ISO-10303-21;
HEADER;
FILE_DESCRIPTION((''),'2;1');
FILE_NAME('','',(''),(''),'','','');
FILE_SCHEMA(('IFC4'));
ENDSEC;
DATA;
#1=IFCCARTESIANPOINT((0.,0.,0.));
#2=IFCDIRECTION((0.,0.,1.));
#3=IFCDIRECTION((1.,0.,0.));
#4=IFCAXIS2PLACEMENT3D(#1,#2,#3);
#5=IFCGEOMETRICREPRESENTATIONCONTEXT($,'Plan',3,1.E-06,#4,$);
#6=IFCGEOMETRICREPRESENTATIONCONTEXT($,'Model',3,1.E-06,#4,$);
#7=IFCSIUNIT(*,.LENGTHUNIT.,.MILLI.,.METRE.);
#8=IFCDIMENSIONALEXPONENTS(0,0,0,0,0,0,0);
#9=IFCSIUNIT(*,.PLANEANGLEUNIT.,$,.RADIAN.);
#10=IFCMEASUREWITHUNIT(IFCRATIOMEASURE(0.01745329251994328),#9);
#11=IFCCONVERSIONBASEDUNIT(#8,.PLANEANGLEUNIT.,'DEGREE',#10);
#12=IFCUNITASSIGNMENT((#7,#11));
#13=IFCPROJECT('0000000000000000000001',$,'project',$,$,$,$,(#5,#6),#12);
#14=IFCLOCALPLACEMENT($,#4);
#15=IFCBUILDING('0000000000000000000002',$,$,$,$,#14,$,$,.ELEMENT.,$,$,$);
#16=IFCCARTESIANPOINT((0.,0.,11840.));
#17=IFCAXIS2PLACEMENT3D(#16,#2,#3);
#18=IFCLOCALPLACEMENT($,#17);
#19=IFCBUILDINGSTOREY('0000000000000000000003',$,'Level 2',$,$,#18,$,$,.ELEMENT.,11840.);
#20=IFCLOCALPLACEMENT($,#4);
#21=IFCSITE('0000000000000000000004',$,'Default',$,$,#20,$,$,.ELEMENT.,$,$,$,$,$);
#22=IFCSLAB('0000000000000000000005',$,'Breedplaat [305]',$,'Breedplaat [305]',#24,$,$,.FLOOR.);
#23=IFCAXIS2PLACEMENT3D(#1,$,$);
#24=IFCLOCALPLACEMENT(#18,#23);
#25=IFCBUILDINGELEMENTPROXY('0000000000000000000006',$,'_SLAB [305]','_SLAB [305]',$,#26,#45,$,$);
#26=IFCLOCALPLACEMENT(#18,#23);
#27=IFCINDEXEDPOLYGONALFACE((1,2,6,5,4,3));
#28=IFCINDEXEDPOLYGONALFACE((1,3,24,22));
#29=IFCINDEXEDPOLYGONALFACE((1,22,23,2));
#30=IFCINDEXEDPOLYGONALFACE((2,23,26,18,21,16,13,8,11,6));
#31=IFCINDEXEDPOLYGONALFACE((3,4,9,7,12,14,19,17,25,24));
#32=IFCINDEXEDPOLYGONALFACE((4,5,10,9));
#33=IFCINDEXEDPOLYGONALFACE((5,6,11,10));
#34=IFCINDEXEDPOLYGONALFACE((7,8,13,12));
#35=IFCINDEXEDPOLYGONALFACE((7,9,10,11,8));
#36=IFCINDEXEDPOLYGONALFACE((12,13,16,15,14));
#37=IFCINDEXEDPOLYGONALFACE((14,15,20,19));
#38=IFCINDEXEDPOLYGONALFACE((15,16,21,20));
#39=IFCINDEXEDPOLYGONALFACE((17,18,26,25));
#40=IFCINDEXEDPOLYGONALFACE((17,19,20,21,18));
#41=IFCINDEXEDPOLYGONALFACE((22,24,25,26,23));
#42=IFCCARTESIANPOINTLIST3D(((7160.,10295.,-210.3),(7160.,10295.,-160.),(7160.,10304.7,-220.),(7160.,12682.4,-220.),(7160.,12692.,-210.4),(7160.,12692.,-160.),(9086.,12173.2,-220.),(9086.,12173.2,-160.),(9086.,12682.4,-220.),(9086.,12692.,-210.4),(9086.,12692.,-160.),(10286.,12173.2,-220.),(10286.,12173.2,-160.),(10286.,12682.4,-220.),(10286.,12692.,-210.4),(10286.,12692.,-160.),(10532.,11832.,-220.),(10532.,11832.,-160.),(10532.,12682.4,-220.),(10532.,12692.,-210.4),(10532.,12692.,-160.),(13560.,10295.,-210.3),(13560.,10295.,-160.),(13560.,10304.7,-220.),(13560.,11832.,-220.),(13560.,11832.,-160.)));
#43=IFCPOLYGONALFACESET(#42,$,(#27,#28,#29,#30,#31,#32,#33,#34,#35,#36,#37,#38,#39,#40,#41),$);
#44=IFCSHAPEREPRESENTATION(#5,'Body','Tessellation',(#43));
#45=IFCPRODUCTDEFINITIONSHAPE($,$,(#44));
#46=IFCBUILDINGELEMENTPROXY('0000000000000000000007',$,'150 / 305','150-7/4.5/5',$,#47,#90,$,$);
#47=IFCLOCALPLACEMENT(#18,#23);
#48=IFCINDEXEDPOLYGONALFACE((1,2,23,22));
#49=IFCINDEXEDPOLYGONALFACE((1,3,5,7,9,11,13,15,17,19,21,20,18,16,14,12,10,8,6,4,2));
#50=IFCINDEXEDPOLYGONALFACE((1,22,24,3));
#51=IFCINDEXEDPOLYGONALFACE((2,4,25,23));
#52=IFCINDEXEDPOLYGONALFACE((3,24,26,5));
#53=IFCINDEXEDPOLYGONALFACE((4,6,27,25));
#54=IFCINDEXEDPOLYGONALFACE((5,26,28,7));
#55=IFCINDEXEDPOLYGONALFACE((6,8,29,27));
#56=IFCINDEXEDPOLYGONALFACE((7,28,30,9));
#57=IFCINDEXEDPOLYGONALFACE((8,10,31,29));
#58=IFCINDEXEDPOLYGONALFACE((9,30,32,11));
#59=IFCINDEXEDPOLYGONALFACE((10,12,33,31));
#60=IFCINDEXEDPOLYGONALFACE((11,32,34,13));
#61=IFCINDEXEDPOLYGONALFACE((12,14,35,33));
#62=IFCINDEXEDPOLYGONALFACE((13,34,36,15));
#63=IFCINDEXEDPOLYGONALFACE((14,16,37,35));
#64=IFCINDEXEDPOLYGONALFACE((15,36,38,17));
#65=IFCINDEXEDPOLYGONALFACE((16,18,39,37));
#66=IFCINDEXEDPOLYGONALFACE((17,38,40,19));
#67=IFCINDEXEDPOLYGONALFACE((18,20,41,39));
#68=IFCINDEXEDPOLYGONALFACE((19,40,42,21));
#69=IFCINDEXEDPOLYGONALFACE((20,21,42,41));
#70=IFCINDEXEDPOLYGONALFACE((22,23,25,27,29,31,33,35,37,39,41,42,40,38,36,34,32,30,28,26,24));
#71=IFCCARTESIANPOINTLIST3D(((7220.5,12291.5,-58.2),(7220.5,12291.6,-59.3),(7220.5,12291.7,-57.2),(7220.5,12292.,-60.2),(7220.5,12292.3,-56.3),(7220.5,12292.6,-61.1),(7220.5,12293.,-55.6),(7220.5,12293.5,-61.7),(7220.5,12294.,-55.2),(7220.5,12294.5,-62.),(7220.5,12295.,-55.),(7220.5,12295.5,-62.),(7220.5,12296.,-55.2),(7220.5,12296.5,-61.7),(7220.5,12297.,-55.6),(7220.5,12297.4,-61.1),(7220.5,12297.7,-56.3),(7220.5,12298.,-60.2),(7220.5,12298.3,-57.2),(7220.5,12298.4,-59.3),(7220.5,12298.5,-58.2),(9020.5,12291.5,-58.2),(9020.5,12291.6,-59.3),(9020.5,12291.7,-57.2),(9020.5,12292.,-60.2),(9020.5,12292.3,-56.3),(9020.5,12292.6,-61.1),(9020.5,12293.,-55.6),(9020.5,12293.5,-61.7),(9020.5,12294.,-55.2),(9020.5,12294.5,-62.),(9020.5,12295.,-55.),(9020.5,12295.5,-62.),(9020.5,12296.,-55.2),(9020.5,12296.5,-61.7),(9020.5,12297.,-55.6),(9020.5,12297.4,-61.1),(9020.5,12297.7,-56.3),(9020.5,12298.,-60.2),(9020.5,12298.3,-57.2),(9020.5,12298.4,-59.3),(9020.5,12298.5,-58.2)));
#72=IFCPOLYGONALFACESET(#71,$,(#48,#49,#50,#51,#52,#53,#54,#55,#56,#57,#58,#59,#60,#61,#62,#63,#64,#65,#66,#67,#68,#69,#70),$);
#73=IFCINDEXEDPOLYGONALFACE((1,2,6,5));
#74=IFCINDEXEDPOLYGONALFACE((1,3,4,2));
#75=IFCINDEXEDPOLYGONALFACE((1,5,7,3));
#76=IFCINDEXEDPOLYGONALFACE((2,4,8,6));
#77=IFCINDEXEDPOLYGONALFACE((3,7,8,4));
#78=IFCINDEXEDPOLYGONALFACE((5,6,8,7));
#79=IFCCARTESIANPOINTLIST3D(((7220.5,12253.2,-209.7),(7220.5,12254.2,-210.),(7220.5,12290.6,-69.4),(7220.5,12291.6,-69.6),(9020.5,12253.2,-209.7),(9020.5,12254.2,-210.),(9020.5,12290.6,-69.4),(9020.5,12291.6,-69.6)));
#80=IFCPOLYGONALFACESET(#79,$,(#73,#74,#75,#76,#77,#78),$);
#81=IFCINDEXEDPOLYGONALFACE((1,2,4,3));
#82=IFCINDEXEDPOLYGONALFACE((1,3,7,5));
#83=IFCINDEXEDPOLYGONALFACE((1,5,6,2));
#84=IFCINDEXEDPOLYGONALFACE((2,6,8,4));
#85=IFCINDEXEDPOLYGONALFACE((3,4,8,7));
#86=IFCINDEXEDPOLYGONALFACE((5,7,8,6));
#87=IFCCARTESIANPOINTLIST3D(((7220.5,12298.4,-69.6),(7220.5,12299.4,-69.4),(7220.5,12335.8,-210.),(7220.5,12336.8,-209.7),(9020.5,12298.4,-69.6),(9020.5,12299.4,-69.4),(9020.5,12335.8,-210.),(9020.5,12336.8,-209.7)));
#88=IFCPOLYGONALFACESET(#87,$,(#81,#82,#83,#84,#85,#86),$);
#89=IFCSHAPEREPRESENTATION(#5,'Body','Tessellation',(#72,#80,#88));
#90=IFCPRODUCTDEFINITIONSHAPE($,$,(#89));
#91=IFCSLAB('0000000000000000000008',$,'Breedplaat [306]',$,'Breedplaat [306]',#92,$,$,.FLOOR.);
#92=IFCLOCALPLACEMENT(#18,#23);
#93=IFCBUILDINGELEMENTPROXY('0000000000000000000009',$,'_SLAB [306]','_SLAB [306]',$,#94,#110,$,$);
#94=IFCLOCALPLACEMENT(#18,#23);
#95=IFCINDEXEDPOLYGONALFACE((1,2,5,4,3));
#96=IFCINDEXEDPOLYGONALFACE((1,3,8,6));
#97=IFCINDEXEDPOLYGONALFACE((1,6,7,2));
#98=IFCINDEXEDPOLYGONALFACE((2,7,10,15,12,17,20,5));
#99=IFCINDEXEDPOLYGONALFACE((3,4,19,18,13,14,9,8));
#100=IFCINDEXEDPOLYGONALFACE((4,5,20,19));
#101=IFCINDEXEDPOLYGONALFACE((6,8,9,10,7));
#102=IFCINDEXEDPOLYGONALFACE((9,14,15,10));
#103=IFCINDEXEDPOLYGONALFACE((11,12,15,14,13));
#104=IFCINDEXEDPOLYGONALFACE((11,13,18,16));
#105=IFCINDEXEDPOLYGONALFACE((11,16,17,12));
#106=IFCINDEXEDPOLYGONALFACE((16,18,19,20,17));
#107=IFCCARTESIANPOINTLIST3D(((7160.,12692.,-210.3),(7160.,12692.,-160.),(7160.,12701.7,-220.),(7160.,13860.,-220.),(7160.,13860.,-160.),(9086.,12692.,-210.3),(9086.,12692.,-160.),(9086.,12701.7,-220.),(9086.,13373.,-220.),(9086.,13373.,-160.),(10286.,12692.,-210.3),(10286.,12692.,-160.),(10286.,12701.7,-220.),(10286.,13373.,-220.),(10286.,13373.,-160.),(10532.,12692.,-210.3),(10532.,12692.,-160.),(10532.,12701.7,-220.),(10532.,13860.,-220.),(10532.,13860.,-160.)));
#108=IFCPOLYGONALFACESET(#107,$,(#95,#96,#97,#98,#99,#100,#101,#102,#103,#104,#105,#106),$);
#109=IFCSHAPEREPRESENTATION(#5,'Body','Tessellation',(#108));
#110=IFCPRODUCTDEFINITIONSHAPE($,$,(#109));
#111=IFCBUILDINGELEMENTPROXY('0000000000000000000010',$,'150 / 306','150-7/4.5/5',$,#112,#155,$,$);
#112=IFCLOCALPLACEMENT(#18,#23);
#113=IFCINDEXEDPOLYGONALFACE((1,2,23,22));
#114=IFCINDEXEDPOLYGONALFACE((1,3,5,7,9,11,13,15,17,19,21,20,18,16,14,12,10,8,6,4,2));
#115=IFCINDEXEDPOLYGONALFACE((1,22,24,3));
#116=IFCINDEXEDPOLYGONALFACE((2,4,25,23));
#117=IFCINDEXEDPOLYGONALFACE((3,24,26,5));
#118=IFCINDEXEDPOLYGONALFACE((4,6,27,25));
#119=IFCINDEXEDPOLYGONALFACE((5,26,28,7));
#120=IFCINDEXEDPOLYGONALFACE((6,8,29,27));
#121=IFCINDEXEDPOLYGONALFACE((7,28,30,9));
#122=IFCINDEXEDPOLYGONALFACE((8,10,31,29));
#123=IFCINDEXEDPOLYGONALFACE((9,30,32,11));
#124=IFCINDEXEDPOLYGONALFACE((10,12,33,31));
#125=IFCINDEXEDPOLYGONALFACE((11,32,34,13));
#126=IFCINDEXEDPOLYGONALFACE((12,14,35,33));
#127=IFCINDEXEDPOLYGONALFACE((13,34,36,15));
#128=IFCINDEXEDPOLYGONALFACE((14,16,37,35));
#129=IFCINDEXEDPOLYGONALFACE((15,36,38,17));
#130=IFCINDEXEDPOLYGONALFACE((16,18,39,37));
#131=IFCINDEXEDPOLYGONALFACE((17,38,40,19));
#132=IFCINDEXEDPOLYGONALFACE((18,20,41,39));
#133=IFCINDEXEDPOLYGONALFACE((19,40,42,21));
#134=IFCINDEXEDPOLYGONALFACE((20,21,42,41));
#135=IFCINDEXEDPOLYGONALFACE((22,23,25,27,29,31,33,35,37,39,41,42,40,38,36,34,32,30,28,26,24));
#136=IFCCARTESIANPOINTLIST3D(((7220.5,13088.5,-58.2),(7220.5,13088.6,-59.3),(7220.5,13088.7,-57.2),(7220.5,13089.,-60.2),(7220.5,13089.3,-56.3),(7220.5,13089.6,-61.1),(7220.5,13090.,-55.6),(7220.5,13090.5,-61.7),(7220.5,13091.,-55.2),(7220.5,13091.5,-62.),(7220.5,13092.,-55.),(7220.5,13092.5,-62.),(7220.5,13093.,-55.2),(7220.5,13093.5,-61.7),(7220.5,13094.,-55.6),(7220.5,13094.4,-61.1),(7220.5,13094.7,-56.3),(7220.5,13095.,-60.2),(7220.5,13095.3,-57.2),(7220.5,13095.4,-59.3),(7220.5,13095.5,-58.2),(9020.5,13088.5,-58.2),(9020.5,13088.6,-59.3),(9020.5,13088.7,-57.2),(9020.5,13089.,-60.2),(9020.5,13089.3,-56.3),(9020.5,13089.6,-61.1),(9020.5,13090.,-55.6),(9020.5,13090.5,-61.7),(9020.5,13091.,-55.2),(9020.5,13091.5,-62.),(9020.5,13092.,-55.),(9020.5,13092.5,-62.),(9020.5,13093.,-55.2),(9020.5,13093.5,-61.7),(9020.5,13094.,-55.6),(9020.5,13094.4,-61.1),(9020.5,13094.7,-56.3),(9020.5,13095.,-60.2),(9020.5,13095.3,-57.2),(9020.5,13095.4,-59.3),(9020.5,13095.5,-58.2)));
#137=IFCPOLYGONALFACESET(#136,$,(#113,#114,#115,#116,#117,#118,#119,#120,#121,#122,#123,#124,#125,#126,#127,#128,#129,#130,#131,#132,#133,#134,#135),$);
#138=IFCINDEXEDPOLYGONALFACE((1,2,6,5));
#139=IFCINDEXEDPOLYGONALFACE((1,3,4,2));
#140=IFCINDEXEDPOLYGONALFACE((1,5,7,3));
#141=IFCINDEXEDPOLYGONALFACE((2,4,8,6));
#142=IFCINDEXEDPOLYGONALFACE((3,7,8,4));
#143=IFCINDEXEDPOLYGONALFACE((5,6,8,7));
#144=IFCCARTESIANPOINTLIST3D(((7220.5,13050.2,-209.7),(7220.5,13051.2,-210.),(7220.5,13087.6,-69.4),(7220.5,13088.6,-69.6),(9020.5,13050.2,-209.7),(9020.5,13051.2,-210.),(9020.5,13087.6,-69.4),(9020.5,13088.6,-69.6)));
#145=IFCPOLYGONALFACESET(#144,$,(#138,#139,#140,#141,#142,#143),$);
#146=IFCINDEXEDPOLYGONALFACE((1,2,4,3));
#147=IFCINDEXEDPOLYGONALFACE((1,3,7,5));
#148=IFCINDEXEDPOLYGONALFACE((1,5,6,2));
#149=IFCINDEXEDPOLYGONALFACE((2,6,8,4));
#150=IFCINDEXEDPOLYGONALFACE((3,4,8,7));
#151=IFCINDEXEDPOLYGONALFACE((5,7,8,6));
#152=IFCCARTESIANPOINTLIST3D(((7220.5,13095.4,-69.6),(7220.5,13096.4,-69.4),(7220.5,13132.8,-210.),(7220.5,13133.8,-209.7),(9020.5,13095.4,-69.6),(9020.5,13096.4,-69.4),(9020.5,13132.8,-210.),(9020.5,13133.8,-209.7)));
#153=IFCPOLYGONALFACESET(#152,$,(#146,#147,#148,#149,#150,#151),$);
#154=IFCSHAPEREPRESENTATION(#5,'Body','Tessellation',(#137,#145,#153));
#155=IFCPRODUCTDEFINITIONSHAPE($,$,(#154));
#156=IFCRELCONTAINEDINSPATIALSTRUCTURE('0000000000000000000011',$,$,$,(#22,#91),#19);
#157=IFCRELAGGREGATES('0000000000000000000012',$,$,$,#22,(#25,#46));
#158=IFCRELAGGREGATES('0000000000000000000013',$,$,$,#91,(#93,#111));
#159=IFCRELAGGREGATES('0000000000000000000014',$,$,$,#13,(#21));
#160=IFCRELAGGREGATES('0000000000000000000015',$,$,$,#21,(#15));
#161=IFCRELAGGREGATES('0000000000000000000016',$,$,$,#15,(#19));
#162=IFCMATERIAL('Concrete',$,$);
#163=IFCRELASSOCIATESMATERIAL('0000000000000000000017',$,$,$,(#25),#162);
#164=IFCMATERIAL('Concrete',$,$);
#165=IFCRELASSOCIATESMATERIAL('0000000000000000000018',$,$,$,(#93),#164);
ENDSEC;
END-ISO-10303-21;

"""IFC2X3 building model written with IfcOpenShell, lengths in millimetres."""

from ifc_helpers import new_model, entity, si_unit, converted_unit, frame, origin_with_axes, origin_2d_with_axis, place, context, project, spatial, polyline, rectangle, circle, outline, extrude, material, element, aggregate, save


model = new_model("IFC2X3")

# Units and contexts
plan_context = context("Plan", 3, precision=1e-06, world=origin_with_axes())
model_context = context("Model", 3, precision=1e-06, world=origin_with_axes())
ifc_project = project(units=[si_unit("LENGTHUNIT", "METRE", prefix="MILLI"), converted_unit("PLANEANGLEUNIT", "DEGREE", entity("IfcRatioMeasure", 0.01745329251994328), si_unit("PLANEANGLEUNIT", "RADIAN"), dimensions=[0, 0, 0, 0, 0, 0, 0])], contexts=[plan_context, model_context])

# Site, building, storey
site_placement = place(None, origin_with_axes())
site = spatial("IfcSite", under=ifc_project, at=site_placement, Name="Default", CompositionType="ELEMENT")
building_placement = place(None, origin_with_axes())
building = spatial("IfcBuilding", under=site, at=building_placement, CompositionType="ELEMENT")
storey_placement = place(None, frame((0.0, 0.0, 11840.0), z_axis=(0.0, 0.0, 1.0), x_axis=(1.0, 0.0, 0.0)))
storey = spatial("IfcBuildingStorey", under=building, at=storey_placement, Name="Level 2", CompositionType="ELEMENT", Elevation=11840.0)

# Slabs, building element proxies, openings
slab_1_placement = place(None, frame((7160.0, 10295.0, 11620.0), z_axis=(0.0, 0.0, 1.0), x_axis=(1.0, 0.0, 0.0)))
slab_1 = element("IfcSlab", 1, at=slab_1_placement, inside=storey, Name="Breedplaat [305]", ObjectType="Breedplaat [305]", PredefinedType="FLOOR")
ifc_material_1 = material(Name="Concrete")
proxy_1_placement = place(slab_1_placement, origin_with_axes())
proxy_1 = element("IfcBuildingElementProxy", 2, at=proxy_1_placement, material=ifc_material_1, Name="_SLAB [305]", Description="_SLAB [305]", context=plan_context, shape_type="SweptSolid", body=[
    extrude(outline(polyline([(6400.0, 1537.0), (3372.0, 1537.0), (3372.0, 2397.0), (0.0, 2397.0), (0.0, 0.0), (6400.0, 0.0), (6400.0, 1537.0)])), origin_with_axes(), (0.0, 0.0, 1.0), 60.0),
])
opening_1_placement = place(slab_1_placement, frame((1926.0, 1878.2, 0.0), z_axis=(0.0, 0.0, 1.0), x_axis=(1.0, 0.0, 0.0)))
element("IfcOpeningElement", 3, at=opening_1_placement, cuts=proxy_1, ObjectType="Opening", context=plan_context, shape_type="SolidModel", body=[
    extrude(rectangle(XDim=1200.0, YDim=519.0, at=origin_2d_with_axis()), frame((600.0, 259.5, 0.0), z_axis=(0.0, 0.0, 1.0), x_axis=(1.0, 0.0, 0.0)), (0.0, 0.0, 1.0), 60.0),
])
opening_2_placement = place(None, frame((7160.0, 10295.0, 11620.0), z_axis=(0.0, 0.0, 1.0), x_axis=(1.0, 0.0, 0.0)))
element("IfcOpeningElement", 4, at=opening_2_placement, cuts=proxy_1, ObjectType="Opening", context=plan_context, shape_type="SweptSolid", body=[
    extrude(outline(polyline([(-0.1, -0.1), (-0.1, 10.0), (10.0, -0.1), (-0.1, -0.1)])), frame((-1.2, -0.1, -0.1), z_axis=(1.0, 0.0, 0.0), x_axis=(0.0, 1.0, 0.0)), (0.0, 0.0, 1.0), 6402.2),
])
opening_3_placement = place(None, frame((7160.0, 10295.0, 11620.0), z_axis=(0.0, 0.0, 1.0), x_axis=(1.0, 0.0, 0.0)))
element("IfcOpeningElement", 5, at=opening_3_placement, cuts=proxy_1, ObjectType="Opening", context=plan_context, shape_type="SweptSolid", body=[
    extrude(outline(polyline([(-0.1, -0.1), (-0.1, 10.0), (10.0, -0.1), (-0.1, -0.1)])), frame((3373.2, 2397.2, -0.1), z_axis=(-1.0, 0.0, 0.0), x_axis=(0.0, -1.0, 0.0)), (0.0, 0.0, 1.0), 3374.2),
])
proxy_2_placement = place(slab_1_placement, frame((60.5, 2000.0, 15.0), z_axis=(0.0, 0.0, 1.0), x_axis=(1.0, 0.0, 0.0)))
proxy_2 = element("IfcBuildingElementProxy", 6, at=proxy_2_placement, Name="150 / 305", Description="150-7/4.5/5", context=plan_context, shape_type="SweptSolid", body=[
    extrude(circle(Radius=3.5, at=origin_2d_with_axis()), frame((0.0, 0.0, 146.5), z_axis=(1.0, 0.0, 0.0), x_axis=(0.0, 0.0, 1.0)), (0.0, 0.0, 1.0), 1800.0),
    extrude(rectangle(XDim=145.2, YDim=1.0, at=origin_2d_with_axis()), frame((0.0, -22.6, 65.3), z_axis=(1.0, 0.0, 0.0), x_axis=(0.0, 0.257663, 0.966235)), (0.0, 0.0, 1.0), 1800.0),
    extrude(rectangle(XDim=145.2, YDim=1.0, at=origin_2d_with_axis()), frame((0.0, 22.6, 65.3), z_axis=(1.0, 0.0, 0.0), x_axis=(0.0, -0.257663, 0.966235)), (0.0, 0.0, 1.0), 1800.0),
])
aggregate(slab_1, [proxy_1, proxy_2])
slab_2_placement = place(None, frame((7160.0, 12692.0, 11620.0), z_axis=(0.0, 0.0, 1.0), x_axis=(1.0, 0.0, 0.0)))
slab_2 = element("IfcSlab", 7, at=slab_2_placement, inside=storey, Name="Breedplaat [306]", ObjectType="Breedplaat [306]", PredefinedType="FLOOR")
ifc_material_2 = material(Name="Concrete")
proxy_3_placement = place(slab_2_placement, origin_with_axes())
proxy_3 = element("IfcBuildingElementProxy", 8, at=proxy_3_placement, material=ifc_material_2, Name="_SLAB [306]", Description="_SLAB [306]", context=plan_context, shape_type="SweptSolid", body=[
    extrude(outline(polyline([(0.0, 1168.0), (0.0, 0.0), (3372.0, 0.0), (3372.0, 1168.0), (0.0, 1168.0)])), origin_with_axes(), (0.0, 0.0, 1.0), 60.0),
])
opening_4_placement = place(slab_2_placement, frame((1926.0, 0.0, 0.0), z_axis=(0.0, 0.0, 1.0), x_axis=(1.0, 0.0, 0.0)))
element("IfcOpeningElement", 9, at=opening_4_placement, cuts=proxy_3, ObjectType="Opening", context=plan_context, shape_type="SolidModel", body=[
    extrude(rectangle(XDim=1200.0, YDim=681.0, at=origin_2d_with_axis()), frame((600.0, 340.5, 0.0), z_axis=(0.0, 0.0, 1.0), x_axis=(1.0, 0.0, 0.0)), (0.0, 0.0, 1.0), 60.0),
])
opening_5_placement = place(None, frame((7160.0, 12692.0, 11620.0), z_axis=(0.0, 0.0, 1.0), x_axis=(1.0, 0.0, 0.0)))
element("IfcOpeningElement", 10, at=opening_5_placement, cuts=proxy_3, ObjectType="Opening", context=plan_context, shape_type="SweptSolid", body=[
    extrude(outline(polyline([(-0.1, -0.1), (-0.1, 10.0), (10.0, -0.1), (-0.1, -0.1)])), frame((-1.2, -0.1, -0.1), z_axis=(1.0, 0.0, 0.0), x_axis=(0.0, 1.0, 0.0)), (0.0, 0.0, 1.0), 3374.2),
])
proxy_4_placement = place(slab_2_placement, frame((60.5, 400.0, 15.0), z_axis=(0.0, 0.0, 1.0), x_axis=(1.0, 0.0, 0.0)))
proxy_4 = element("IfcBuildingElementProxy", 11, at=proxy_4_placement, Name="150 / 306", Description="150-7/4.5/5", context=plan_context, shape_type="SweptSolid", body=[
    extrude(circle(Radius=3.5, at=origin_2d_with_axis()), frame((0.0, 0.0, 146.5), z_axis=(1.0, 0.0, 0.0), x_axis=(0.0, 0.0, 1.0)), (0.0, 0.0, 1.0), 1800.0),
    extrude(rectangle(XDim=145.2, YDim=1.0, at=origin_2d_with_axis()), frame((0.0, -22.6, 65.3), z_axis=(1.0, 0.0, 0.0), x_axis=(0.0, 0.257663, 0.966235)), (0.0, 0.0, 1.0), 1800.0),
    extrude(rectangle(XDim=145.2, YDim=1.0, at=origin_2d_with_axis()), frame((0.0, 22.6, 65.3), z_axis=(1.0, 0.0, 0.0), x_axis=(0.0, -0.257663, 0.966235)), (0.0, 0.0, 1.0), 1800.0),
])
aggregate(slab_2, [proxy_3, proxy_4])

save(model, "model.ifc")
